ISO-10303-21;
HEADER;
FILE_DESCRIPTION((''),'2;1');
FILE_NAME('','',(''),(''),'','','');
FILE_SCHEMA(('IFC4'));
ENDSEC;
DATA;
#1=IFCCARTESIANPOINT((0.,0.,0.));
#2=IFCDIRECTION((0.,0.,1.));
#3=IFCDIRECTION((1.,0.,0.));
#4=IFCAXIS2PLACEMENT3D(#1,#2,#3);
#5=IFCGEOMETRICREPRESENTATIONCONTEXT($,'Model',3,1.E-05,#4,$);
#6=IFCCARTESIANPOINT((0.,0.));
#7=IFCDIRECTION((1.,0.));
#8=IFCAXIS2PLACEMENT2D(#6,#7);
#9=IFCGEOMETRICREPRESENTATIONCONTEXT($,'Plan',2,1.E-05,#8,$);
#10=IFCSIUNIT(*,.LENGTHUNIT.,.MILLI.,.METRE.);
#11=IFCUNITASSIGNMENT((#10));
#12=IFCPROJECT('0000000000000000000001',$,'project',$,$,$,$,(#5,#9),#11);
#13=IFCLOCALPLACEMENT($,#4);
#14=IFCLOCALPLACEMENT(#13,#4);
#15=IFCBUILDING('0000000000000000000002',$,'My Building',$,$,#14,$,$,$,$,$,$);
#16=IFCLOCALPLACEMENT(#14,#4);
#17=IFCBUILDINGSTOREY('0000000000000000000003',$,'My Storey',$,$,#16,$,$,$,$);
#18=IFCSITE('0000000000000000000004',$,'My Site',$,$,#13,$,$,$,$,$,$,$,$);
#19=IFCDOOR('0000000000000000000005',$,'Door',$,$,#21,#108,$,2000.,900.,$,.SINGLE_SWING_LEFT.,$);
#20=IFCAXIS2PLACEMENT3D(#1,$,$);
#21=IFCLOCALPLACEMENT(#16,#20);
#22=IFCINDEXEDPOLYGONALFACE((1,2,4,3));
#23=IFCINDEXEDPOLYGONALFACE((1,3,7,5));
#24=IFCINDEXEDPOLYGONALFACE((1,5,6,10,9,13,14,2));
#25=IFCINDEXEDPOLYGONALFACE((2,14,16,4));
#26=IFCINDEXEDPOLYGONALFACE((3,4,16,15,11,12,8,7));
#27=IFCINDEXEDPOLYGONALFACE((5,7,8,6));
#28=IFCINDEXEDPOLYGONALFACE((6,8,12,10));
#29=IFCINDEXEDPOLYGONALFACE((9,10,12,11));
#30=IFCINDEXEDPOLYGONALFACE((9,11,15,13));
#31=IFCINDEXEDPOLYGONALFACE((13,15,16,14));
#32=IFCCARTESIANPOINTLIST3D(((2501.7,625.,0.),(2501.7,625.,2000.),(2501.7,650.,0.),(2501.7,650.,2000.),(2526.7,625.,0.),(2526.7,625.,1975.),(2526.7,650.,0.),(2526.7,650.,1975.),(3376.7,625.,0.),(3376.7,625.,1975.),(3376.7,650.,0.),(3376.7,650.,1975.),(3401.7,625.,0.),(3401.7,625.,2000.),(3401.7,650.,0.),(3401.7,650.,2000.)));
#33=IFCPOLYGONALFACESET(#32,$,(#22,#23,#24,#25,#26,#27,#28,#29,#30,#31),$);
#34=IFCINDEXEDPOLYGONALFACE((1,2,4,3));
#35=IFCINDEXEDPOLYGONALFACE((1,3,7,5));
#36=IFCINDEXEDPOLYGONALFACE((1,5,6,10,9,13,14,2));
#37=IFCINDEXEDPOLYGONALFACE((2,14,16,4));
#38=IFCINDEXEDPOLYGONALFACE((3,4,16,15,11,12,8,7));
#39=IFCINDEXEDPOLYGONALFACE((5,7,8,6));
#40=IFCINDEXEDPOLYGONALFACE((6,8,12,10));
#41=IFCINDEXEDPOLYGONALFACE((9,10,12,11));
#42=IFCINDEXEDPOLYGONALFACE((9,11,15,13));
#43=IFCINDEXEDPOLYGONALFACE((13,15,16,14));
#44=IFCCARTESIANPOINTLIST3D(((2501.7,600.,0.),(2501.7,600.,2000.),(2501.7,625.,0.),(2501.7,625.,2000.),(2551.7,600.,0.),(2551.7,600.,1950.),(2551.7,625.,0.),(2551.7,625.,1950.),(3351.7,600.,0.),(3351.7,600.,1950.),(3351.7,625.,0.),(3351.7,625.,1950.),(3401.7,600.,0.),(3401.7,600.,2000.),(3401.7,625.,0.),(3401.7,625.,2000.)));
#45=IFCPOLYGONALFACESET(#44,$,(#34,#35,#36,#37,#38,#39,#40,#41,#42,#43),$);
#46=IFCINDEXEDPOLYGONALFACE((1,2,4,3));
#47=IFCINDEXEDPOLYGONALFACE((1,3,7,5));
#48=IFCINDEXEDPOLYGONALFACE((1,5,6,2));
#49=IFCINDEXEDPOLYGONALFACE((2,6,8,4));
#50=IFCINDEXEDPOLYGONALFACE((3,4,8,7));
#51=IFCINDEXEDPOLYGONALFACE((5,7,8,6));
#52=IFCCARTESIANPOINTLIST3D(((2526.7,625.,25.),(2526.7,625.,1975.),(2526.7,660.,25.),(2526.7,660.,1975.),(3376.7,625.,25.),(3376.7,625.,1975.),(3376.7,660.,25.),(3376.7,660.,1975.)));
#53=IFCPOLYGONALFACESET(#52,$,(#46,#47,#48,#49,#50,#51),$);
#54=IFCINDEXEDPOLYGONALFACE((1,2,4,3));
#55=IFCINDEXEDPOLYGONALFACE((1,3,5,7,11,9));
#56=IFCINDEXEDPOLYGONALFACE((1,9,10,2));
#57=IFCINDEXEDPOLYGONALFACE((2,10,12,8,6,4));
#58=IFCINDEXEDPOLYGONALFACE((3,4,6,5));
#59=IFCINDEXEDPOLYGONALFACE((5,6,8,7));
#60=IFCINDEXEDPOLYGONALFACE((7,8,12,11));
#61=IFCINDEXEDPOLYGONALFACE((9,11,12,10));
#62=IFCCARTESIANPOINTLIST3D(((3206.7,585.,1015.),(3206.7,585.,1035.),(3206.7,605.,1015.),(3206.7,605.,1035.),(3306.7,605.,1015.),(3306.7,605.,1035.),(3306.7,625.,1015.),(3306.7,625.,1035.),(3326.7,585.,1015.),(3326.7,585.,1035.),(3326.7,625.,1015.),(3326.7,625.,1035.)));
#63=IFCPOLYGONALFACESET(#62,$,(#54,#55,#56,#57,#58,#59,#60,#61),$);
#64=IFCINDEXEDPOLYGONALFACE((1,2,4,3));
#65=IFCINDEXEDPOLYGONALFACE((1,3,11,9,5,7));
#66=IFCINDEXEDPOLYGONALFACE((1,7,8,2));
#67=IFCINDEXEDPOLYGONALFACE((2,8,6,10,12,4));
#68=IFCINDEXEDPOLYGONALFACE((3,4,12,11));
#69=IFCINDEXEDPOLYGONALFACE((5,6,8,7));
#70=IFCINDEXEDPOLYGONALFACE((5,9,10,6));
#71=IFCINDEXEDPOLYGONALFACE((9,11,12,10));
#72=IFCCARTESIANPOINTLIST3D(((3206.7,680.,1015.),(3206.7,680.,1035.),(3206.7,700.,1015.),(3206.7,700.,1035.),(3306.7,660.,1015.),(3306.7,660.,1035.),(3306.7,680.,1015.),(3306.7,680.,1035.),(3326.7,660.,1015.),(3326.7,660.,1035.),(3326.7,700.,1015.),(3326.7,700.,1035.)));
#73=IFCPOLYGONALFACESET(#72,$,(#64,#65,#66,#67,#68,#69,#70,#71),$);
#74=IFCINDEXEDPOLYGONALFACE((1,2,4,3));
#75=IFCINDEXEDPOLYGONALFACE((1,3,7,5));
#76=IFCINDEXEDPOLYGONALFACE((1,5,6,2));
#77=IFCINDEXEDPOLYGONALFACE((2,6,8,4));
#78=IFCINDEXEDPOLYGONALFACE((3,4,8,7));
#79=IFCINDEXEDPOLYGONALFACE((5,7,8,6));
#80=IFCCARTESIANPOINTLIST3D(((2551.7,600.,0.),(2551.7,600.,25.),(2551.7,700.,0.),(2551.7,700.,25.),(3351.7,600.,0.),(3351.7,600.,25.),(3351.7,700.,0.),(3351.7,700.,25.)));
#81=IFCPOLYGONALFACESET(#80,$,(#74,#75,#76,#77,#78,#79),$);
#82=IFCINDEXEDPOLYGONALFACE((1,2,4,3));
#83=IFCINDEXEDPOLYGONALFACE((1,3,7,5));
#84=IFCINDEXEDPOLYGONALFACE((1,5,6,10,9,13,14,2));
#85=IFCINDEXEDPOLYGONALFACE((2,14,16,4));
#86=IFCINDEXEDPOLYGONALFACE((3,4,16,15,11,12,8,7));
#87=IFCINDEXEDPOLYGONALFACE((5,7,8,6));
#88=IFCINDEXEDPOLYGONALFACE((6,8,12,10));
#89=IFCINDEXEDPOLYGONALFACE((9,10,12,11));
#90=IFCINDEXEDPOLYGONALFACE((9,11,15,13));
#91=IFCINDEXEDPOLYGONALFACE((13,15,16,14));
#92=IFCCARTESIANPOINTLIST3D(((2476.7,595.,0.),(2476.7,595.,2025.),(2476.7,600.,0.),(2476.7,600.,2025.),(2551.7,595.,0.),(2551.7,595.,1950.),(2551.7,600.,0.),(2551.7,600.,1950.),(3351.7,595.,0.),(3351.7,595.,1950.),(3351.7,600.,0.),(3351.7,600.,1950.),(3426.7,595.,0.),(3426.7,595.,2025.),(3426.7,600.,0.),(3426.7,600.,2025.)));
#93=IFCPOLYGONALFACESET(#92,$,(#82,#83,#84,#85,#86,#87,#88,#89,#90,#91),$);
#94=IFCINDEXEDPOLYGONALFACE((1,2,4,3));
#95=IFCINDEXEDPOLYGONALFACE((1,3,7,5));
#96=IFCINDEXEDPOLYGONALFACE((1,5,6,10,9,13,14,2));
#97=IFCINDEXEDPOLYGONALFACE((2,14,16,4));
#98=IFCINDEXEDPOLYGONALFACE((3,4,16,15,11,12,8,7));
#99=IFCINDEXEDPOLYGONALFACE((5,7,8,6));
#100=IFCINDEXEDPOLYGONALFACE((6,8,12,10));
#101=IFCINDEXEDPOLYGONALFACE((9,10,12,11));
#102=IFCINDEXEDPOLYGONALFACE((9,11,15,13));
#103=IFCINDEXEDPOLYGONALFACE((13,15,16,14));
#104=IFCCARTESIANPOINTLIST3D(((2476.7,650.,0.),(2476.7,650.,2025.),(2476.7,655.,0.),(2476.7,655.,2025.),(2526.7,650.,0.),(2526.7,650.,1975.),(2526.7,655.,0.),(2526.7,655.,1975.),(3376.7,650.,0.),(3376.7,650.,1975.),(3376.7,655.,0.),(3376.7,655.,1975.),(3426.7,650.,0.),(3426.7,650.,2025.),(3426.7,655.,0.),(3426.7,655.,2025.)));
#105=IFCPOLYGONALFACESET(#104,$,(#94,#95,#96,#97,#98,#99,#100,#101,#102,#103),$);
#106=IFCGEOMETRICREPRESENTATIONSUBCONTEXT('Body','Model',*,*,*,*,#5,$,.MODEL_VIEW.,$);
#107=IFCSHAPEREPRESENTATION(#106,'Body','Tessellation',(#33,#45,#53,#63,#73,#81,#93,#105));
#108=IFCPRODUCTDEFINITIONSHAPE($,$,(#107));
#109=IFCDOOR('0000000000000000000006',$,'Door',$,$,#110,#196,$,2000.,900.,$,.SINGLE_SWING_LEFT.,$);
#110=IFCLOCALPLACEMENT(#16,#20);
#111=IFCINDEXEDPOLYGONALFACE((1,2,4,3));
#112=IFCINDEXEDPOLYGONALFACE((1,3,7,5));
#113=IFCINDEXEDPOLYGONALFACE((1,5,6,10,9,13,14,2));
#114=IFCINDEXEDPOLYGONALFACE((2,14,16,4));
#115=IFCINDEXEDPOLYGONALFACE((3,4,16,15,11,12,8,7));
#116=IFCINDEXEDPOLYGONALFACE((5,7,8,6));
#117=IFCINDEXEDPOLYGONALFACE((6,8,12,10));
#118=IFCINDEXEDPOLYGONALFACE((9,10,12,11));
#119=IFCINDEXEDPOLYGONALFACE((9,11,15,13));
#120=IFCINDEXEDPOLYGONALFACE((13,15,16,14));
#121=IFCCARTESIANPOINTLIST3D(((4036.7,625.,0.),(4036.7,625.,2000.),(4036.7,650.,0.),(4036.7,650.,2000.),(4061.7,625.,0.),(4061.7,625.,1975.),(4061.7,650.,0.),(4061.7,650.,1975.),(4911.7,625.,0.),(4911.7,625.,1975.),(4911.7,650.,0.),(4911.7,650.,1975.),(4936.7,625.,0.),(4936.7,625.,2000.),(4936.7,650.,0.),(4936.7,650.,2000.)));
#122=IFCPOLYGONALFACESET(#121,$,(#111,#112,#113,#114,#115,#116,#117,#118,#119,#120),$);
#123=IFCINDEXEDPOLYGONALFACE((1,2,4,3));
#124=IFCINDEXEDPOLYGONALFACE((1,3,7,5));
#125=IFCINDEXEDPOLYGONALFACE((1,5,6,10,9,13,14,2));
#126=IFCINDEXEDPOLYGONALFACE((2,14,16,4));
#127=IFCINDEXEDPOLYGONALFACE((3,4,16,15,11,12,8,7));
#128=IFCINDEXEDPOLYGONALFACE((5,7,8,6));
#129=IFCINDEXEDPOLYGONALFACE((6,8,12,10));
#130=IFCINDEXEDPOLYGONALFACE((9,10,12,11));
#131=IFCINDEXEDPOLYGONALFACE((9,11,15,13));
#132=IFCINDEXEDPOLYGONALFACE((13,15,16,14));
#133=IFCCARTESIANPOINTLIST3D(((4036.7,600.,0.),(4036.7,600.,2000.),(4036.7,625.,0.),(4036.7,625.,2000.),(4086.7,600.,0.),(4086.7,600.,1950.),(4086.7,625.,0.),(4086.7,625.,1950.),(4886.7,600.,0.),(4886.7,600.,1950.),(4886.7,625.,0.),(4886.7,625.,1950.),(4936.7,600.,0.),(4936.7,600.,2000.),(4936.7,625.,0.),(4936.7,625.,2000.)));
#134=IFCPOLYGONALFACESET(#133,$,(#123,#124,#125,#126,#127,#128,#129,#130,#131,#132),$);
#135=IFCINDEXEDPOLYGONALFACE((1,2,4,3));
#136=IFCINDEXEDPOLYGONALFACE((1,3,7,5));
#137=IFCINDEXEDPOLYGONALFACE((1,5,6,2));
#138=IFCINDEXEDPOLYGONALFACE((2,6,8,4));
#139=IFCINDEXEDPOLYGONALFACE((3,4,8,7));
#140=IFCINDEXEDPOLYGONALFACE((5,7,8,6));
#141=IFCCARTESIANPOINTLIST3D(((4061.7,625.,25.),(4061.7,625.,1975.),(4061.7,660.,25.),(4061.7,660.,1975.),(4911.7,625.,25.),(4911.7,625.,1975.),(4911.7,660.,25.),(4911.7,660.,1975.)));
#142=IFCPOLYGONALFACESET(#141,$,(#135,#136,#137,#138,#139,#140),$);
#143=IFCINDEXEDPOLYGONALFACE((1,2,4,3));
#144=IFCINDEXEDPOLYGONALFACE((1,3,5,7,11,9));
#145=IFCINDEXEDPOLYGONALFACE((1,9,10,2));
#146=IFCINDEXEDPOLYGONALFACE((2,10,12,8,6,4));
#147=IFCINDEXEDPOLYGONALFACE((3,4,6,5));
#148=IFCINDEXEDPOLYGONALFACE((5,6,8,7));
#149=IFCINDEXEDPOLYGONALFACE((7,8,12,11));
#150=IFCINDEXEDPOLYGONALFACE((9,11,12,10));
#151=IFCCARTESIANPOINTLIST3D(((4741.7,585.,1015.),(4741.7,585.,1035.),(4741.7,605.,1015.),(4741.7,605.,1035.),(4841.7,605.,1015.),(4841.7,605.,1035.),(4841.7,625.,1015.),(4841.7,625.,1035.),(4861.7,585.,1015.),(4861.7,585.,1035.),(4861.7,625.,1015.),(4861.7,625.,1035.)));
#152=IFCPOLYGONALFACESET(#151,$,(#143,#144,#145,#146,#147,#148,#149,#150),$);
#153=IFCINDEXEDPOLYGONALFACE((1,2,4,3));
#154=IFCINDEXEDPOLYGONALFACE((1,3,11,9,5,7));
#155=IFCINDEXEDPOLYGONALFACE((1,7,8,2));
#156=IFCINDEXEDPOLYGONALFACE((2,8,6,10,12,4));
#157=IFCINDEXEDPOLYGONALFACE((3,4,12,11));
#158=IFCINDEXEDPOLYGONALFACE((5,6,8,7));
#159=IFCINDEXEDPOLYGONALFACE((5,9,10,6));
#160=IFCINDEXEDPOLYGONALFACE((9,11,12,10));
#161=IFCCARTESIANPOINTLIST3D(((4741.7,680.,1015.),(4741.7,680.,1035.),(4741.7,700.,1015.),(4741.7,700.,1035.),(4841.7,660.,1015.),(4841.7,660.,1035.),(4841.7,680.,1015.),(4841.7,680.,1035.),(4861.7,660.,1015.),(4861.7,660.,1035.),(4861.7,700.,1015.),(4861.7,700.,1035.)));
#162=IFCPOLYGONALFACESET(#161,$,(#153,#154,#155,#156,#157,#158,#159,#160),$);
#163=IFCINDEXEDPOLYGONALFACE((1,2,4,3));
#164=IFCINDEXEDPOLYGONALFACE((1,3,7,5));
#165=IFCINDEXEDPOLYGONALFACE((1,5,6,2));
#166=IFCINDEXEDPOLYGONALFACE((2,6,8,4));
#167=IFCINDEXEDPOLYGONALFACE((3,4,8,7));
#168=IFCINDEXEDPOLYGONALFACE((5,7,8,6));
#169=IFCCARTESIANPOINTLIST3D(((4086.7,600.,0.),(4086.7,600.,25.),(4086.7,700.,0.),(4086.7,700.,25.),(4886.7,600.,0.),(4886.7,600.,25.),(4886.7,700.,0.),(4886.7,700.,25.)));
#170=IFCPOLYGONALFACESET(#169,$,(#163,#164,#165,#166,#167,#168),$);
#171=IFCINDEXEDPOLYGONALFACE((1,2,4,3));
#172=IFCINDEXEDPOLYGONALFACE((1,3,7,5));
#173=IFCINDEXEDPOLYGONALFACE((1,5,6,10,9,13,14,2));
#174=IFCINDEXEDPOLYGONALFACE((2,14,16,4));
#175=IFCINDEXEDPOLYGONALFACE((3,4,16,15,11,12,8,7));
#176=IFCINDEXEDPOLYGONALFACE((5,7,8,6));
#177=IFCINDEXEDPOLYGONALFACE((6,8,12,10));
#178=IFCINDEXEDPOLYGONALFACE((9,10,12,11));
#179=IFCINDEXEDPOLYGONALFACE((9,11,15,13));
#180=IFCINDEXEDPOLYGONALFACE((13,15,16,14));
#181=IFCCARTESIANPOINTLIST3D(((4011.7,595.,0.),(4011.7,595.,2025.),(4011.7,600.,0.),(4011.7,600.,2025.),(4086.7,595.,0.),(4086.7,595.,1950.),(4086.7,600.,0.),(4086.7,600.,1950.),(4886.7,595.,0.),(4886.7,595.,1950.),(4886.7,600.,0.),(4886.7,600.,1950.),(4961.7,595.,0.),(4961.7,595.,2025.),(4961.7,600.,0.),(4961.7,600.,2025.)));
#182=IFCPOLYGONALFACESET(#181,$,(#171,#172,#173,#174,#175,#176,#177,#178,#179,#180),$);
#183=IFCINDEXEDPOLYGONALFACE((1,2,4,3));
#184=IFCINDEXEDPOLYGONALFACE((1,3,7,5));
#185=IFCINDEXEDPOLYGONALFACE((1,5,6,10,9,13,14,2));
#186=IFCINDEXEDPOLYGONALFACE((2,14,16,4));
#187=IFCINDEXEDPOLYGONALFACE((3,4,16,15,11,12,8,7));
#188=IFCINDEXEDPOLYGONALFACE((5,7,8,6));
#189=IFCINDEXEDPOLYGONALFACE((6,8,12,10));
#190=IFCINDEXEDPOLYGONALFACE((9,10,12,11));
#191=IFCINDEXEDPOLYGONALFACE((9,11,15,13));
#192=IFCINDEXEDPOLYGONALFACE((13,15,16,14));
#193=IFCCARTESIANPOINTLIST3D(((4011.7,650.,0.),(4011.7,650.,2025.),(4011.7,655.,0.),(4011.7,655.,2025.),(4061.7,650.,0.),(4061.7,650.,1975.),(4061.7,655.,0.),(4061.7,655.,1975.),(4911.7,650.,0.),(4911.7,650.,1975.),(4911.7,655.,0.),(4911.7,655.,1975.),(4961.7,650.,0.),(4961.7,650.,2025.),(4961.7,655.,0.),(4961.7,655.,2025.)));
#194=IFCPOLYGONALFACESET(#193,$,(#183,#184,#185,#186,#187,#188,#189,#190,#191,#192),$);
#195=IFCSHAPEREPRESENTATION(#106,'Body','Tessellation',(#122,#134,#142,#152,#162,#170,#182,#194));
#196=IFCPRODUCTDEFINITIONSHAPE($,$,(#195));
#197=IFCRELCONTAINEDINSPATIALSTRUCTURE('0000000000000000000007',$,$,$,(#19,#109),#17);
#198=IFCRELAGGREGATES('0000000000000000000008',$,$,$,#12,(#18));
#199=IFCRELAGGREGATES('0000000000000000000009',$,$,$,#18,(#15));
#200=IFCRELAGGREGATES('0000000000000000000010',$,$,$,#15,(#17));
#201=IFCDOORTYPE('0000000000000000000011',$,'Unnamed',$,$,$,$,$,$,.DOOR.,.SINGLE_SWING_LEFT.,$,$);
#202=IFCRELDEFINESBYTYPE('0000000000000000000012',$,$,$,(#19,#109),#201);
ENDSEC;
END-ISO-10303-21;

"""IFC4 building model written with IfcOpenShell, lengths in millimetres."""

from ifc_helpers import new_model, entity, si_unit, frame, origin_with_axes, origin_2d_with_axis, place, context, subcontext, project, spatial, line, indexed_curve, outline, extrude, shape, source, transform, mapped, type_object, type_shapes, element, save


model = new_model("IFC4")

# Units and contexts
model_context = context("Model", 3, precision=1e-05, world=origin_with_axes())
plan_context = context("Plan", 2, precision=1e-05, world=origin_2d_with_axis())
body_context_1 = subcontext(model_context, "Body", "Model", "MODEL_VIEW")
body_context_2 = subcontext(plan_context, "Body", "Plan", "PLAN_VIEW")
ifc_project = project(units=[si_unit("LENGTHUNIT", "METRE", prefix="MILLI")], contexts=[model_context, plan_context])

# Site, building, storey
site_placement = place(None, origin_with_axes())
site = spatial("IfcSite", under=ifc_project, at=site_placement, Name="My Site")
building_placement = place(site_placement, origin_with_axes())
building = spatial("IfcBuilding", under=site, at=building_placement, Name="My Building")
storey_placement = place(building_placement, origin_with_axes())
storey = spatial("IfcBuildingStorey", under=building, at=storey_placement, Name="My Storey")

# Shared definitions
door_type = type_object("IfcDoorType", Name="Unnamed", OperationType="SINGLE_SWING_LEFT", PredefinedType="DOOR")
shared_shape_1 = source(origin_with_axes(), body_context_1, "Body", "SweptSolid", [
    extrude(outline(indexed_curve([(0.0, 0.0), (0.0, 2000.0), (900.0, 2000.0), (900.0, 0.0), (875.0, 0.0), (875.0, 1975.0), (25.0, 1975.0), (25.0, 0.0)], segments=[line(1, 2, 3, 4, 5, 6, 7, 8, 1)])), frame((0.0, 25.0, 0.0), z_axis=(0.0, -1.0, 0.0), x_axis=(1.0, 0.0, 0.0)), (0.0, 0.0, -1.0), 25.0),
    extrude(outline(indexed_curve([(0.0, 0.0), (0.0, 2000.0), (900.0, 2000.0), (900.0, 0.0), (850.0, 0.0), (850.0, 1950.0), (50.0, 1950.0), (50.0, 0.0)], segments=[line(1, 2, 3, 4, 5, 6, 7, 8, 1)])), frame((0.0, 0.0, 0.0), z_axis=(0.0, -1.0, 0.0), x_axis=(1.0, 0.0, 0.0)), (0.0, 0.0, -1.0), 25.0),
    extrude(outline(indexed_curve([(0.0, 0.0), (850.0, 0.0), (850.0, 35.0), (0.0, 35.0)], segments=[line(1, 2, 3, 4, 1)])), frame((25.0, 25.0, 25.0), z_axis=(0.0, 0.0, 1.0), x_axis=(1.0, 0.0, 0.0)), (0.0, 0.0, 1.0), 1950.0),
    extrude(outline(indexed_curve([(0.0, 0.0), (0.0, -40.0), (-120.0, -40.0), (-120.0, -20.0), (-20.0, -20.0), (-20.0, 0.0)], segments=[line(1, 2, 3, 4, 5, 6, 1)])), frame((825.0, 25.0, 1015.0), z_axis=(0.0, 0.0, 1.0), x_axis=(1.0, 0.0, 0.0)), (0.0, 0.0, 1.0), 20.0),
    extrude(outline(indexed_curve([(0.0, 0.0), (0.0, 40.0), (-120.0, 40.0), (-120.0, 20.0), (-20.0, 20.0), (-20.0, 0.0)], segments=[line(1, 2, 3, 4, 5, 6, 1)])), frame((825.0, 60.0, 1015.0), z_axis=(0.0, 0.0, 1.0), x_axis=(1.0, 0.0, 0.0)), (0.0, 0.0, 1.0), 20.0),
    extrude(outline(indexed_curve([(0.0, 0.0), (800.0, 0.0), (800.0, 100.0), (0.0, 100.0)], segments=[line(1, 2, 3, 4, 1)])), frame((50.0, 0.0, 0.0), z_axis=(0.0, 0.0, 1.0), x_axis=(1.0, 0.0, 0.0)), (0.0, 0.0, 1.0), 25.0),
    extrude(outline(indexed_curve([(0.0, 0.0), (0.0, 2025.0), (950.0, 2025.0), (950.0, 0.0), (875.0, 0.0), (875.0, 1950.0), (75.0, 1950.0), (75.0, 0.0)], segments=[line(1, 2, 3, 4, 5, 6, 7, 8, 1)])), frame((-25.0, -5.0, 0.0), z_axis=(0.0, -1.0, 0.0), x_axis=(1.0, 0.0, 0.0)), (0.0, 0.0, -1.0), 5.0),
    extrude(outline(indexed_curve([(0.0, 0.0), (0.0, 2025.0), (950.0, 2025.0), (950.0, 0.0), (900.0, 0.0), (900.0, 1975.0), (50.0, 1975.0), (50.0, 0.0)], segments=[line(1, 2, 3, 4, 5, 6, 7, 8, 1)])), frame((-25.0, 50.0, 0.0), z_axis=(0.0, -1.0, 0.0), x_axis=(1.0, 0.0, 0.0)), (0.0, 0.0, -1.0), 5.0),
])
shared_shape_2 = source(origin_with_axes(), body_context_2, "Body", "Curve2D", [
    entity("IfcIndexedPolyCurve", entity("IfcCartesianPointList2D", [[0.0, 0.0], [0.0, 50.0], [25.0, 50.0], [25.0, 25.0], [50.0, 25.0], [50.0, 0.0]]), [entity("IfcLineIndex", [1, 2, 3, 4, 5, 6, 1])]),
    entity("IfcIndexedPolyCurve", entity("IfcCartesianPointList2D", [[900.0, 0.0], [900.0, 50.0], [875.0, 50.0], [875.0, 25.0], [850.0, 25.0], [850.0, 0.0]]), [entity("IfcLineIndex", [1, 2, 3, 4, 5, 6, 1])]),
    entity("IfcTrimmedCurve", entity("IfcEllipse", entity("IfcAxis2Placement2D", entity("IfcCartesianPoint", [60.0, 50.0]), entity("IfcDirection", [1.0, 0.0])), 815.0, 850.0), [entity("IfcCartesianPoint", [875.0, 50.0])], [entity("IfcCartesianPoint", [60.0, 900.0])], True, "CARTESIAN"),
    entity("IfcIndexedPolyCurve", entity("IfcCartesianPointList2D", [[25.0, 50.0], [60.0, 50.0], [60.0, 900.0], [25.0, 900.0]]), [entity("IfcLineIndex", [1, 2, 3, 4, 1])]),
])
type_shapes(door_type, [shared_shape_1, shared_shape_2])

# Doors
for number, where, z_axis, x_axis, name in (
    (1, (2501.7, 600.0, 0.0), (0.0, 0.0, 1.0), (1.0, 0.0, 0.0), "Door"),
    (2, (4036.7, 600.0, 0.0), (0.0, 0.0, 1.0), (1.0, 0.0, 0.0), "Door"),
):
    element("IfcDoor", number, at=place(storey_placement, frame(where, z_axis=z_axis, x_axis=x_axis)), inside=storey, type_object=door_type, Name=name, OperationType="SINGLE_SWING_LEFT", OverallHeight=2000.0, OverallWidth=900.0, shapes=[
        shape(body_context_1, "Body", "MappedRepresentation", [mapped(shared_shape_1, transform((0.0, 0.0, 0.0), x_axis=(1.0, 0.0, 0.0), y_axis=(0.0, 1.0, 0.0), z_axis=(0.0, 0.0, 1.0), scale=1.0))]),
        shape(body_context_2, "Body", "MappedRepresentation", [mapped(shared_shape_2, transform((0.0, 0.0, 0.0), x_axis=(1.0, 0.0, 0.0), y_axis=(0.0, 1.0, 0.0), z_axis=(0.0, 0.0, 1.0), scale=1.0))]),
    ])

save(model, "model.ifc")
